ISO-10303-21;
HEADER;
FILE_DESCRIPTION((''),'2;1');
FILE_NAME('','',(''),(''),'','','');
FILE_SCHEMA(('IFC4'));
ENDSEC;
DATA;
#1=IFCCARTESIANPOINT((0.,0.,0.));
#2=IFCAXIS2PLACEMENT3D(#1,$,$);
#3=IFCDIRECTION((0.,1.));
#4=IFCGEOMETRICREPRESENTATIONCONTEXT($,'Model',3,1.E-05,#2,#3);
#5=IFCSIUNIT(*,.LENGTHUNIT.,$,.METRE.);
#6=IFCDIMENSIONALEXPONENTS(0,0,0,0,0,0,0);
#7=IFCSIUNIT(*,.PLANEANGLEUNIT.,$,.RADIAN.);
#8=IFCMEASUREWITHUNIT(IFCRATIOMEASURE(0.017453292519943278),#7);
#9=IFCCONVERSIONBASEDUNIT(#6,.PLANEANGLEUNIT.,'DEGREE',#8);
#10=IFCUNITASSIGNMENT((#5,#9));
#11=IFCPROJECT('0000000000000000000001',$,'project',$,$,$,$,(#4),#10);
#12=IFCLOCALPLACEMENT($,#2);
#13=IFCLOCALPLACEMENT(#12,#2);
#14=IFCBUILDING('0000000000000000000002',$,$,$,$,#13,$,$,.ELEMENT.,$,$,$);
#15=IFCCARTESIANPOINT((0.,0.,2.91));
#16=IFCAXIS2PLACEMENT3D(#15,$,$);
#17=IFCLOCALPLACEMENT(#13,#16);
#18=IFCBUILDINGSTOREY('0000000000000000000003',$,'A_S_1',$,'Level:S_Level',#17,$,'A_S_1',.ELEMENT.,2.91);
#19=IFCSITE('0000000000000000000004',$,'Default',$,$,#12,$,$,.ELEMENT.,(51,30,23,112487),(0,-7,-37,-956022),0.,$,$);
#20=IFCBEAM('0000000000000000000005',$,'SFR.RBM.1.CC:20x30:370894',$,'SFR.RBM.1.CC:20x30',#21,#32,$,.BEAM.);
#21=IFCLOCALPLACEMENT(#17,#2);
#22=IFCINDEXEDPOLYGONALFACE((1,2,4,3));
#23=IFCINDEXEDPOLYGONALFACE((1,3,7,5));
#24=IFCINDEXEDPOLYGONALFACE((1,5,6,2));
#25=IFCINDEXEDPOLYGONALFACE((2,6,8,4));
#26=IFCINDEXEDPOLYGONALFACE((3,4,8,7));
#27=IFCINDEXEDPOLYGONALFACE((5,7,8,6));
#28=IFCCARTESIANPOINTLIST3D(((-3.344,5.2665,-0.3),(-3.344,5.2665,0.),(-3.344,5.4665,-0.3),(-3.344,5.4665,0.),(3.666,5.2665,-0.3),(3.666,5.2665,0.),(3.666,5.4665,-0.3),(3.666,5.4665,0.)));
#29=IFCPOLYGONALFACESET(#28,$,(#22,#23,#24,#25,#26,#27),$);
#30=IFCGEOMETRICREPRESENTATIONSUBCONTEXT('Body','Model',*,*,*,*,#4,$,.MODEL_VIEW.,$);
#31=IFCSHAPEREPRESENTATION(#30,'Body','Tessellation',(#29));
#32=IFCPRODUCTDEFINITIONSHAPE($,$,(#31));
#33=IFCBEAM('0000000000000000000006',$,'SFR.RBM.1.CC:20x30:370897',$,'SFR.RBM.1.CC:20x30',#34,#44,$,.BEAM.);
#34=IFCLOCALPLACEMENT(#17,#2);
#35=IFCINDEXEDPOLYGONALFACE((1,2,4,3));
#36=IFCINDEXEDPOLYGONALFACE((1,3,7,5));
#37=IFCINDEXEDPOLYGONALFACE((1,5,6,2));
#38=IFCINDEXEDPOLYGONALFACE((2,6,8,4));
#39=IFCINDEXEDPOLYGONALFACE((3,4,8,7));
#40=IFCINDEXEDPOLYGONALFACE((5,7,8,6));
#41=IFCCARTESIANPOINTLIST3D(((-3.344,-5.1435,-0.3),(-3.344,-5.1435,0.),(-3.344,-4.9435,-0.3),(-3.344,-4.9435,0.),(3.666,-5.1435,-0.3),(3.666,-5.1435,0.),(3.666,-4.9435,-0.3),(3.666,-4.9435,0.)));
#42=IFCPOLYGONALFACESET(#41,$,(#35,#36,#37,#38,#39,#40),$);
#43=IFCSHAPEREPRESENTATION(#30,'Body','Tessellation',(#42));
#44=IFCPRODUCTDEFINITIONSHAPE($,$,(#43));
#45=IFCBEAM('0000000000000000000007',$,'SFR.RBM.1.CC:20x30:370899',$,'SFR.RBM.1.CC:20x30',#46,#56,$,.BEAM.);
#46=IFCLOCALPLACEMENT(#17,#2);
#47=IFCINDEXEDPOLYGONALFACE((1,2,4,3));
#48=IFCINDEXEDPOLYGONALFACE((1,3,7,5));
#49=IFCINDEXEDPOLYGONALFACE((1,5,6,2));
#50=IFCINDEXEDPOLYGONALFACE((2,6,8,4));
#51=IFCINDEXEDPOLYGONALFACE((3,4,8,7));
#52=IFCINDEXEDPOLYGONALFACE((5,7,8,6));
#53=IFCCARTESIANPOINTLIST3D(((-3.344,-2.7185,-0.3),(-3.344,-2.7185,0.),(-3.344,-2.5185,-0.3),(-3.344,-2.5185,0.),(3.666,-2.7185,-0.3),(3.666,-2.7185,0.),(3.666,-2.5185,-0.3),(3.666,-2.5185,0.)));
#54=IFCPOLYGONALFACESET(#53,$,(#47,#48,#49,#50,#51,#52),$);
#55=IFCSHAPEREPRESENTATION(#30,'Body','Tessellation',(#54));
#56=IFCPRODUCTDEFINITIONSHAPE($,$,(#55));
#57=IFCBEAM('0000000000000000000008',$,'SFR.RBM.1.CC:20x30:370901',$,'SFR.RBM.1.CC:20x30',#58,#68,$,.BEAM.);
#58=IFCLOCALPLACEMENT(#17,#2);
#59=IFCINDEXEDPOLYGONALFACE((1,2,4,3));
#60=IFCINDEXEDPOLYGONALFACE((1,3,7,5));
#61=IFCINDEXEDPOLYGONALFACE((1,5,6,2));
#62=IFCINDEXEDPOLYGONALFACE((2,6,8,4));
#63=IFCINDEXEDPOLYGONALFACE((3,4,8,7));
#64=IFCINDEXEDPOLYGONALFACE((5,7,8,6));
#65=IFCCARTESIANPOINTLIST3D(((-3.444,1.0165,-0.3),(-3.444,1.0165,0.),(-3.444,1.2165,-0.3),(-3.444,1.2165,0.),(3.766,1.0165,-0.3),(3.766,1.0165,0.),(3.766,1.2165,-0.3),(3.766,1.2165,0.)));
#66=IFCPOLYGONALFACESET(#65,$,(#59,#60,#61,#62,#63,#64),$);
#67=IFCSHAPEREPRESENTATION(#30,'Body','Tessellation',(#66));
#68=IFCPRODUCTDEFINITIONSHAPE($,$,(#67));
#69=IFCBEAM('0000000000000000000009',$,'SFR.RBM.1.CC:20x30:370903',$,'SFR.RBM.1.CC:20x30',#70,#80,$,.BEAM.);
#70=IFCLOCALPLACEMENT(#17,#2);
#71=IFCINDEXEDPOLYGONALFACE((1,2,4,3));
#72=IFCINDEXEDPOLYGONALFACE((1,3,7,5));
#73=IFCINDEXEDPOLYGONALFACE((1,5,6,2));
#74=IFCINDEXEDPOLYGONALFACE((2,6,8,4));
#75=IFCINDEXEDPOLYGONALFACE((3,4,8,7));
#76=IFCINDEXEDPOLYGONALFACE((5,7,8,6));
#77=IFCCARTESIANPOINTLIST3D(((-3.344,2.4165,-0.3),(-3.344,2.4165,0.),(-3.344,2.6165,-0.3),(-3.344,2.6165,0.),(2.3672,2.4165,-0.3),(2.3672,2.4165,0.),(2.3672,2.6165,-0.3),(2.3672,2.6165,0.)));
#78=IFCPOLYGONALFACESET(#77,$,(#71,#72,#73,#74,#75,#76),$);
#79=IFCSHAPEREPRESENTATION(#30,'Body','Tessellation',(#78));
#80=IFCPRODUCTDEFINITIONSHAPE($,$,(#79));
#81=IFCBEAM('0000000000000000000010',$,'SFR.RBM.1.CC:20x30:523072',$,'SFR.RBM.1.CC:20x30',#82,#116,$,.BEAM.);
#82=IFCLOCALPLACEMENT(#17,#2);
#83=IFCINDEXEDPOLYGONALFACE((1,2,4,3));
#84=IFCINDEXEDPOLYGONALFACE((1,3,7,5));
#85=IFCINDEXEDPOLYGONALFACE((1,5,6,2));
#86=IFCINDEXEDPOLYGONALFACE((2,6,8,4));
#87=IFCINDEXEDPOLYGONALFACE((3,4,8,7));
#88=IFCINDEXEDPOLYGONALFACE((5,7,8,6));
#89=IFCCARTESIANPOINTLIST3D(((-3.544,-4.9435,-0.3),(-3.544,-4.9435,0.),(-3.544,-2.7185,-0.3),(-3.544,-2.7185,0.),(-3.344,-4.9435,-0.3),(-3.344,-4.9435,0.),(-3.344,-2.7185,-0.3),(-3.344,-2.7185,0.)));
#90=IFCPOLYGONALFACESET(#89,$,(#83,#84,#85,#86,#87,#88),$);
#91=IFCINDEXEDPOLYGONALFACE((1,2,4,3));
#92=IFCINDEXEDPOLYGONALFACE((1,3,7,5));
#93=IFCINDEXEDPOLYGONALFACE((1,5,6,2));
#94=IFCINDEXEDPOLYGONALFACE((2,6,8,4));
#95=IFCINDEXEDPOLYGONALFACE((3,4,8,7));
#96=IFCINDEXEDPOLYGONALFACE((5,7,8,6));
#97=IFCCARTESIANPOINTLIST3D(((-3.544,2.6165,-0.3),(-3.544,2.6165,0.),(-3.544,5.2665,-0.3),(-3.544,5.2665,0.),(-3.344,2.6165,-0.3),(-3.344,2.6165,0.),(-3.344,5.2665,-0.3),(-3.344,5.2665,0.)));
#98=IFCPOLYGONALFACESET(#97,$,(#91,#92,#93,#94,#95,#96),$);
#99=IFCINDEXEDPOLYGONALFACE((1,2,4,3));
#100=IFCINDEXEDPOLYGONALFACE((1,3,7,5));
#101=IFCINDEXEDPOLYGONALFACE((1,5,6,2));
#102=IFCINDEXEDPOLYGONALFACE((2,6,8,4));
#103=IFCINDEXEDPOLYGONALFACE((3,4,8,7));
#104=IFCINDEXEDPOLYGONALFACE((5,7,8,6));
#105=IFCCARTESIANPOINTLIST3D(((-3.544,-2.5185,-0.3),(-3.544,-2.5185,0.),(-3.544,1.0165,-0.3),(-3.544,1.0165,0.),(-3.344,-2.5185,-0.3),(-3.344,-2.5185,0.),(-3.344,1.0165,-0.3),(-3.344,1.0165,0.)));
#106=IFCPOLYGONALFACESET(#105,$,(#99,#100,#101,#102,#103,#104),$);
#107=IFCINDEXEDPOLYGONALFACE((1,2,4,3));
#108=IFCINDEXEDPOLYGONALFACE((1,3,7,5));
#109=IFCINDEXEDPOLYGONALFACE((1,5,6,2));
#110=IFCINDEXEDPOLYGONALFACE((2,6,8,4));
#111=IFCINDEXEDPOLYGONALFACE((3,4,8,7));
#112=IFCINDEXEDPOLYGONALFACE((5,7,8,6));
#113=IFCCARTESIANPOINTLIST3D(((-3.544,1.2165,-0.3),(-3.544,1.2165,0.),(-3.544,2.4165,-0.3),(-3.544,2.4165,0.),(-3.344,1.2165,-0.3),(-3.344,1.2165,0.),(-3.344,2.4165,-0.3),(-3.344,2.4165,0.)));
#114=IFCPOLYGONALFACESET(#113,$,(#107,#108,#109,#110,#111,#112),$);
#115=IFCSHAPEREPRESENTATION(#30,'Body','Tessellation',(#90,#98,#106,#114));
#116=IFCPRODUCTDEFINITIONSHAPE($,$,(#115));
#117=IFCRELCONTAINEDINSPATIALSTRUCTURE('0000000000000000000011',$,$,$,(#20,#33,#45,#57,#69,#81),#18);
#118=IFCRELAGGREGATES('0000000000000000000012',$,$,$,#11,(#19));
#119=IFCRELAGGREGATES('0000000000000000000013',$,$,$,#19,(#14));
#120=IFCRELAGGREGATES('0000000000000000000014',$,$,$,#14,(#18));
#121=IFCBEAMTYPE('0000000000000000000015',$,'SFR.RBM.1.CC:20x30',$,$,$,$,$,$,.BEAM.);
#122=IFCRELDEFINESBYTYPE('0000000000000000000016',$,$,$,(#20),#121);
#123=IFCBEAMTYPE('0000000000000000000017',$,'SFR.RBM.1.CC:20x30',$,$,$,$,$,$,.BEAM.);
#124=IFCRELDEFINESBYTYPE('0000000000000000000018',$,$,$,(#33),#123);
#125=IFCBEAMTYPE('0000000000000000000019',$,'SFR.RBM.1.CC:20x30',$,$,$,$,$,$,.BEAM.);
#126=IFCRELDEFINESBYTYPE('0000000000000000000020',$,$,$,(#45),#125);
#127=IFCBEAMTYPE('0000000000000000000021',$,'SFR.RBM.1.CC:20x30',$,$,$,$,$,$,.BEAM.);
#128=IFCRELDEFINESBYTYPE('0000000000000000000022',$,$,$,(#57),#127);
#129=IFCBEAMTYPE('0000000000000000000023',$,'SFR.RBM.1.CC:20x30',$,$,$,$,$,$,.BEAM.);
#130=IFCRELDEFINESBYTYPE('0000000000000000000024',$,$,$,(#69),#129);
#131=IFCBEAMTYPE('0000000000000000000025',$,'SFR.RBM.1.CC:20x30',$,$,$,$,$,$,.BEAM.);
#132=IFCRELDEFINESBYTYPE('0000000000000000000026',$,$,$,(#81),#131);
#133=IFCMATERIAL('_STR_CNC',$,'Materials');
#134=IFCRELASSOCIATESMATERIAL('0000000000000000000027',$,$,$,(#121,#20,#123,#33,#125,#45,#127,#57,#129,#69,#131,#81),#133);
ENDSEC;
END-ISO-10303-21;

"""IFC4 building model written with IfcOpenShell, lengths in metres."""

from ifc_helpers import new_model, entity, si_unit, converted_unit, direction, frame, origin, place, context, subcontext, project, spatial, indexed_curve, outline, extrude, source, transform, mapped, material, type_object, type_shapes, element, save


model = new_model("IFC4")

# Units and contexts
model_context = context("Model", 3, precision=1e-05, world=origin(), true_north=direction((0.0, 1.0)))
body_context = subcontext(model_context, "Body", "Model", "MODEL_VIEW")
ifc_project = project(units=[si_unit("LENGTHUNIT", "METRE"), converted_unit("PLANEANGLEUNIT", "DEGREE", entity("IfcRatioMeasure", 0.017453292519943278), si_unit("PLANEANGLEUNIT", "RADIAN"), dimensions=[0, 0, 0, 0, 0, 0, 0])], contexts=[model_context])

# Site, building, storey
site_placement = place(None, origin())
site = spatial("IfcSite", under=ifc_project, at=site_placement, Name="Default", CompositionType="ELEMENT", RefLatitude=(51, 30, 23, 112487), RefLongitude=(0, -7, -37, -956022), RefElevation=0.0)
building_placement = place(site_placement, origin())
building = spatial("IfcBuilding", under=site, at=building_placement, CompositionType="ELEMENT")
storey_placement = place(building_placement, frame((0.0, 0.0, 2.91)))
storey = spatial("IfcBuildingStorey", under=building, at=storey_placement, Name="A_S_1", ObjectType="Level:S_Level", LongName="A_S_1", CompositionType="ELEMENT", Elevation=2.91)

# Shared definitions
ifc_material_1 = material(Name="_STR_CNC", Category="Materials")

# Beams
beam_type_1 = type_object("IfcBeamType", Name="SFR.RBM.1.CC:20x30", PredefinedType="BEAM", material=ifc_material_1)
shared_shape_1 = source(origin(), body_context, "Body", "SweptSolid", [
    extrude(outline(indexed_curve([(-0.15, -0.1), (0.15, -0.1), (0.15, 0.1), (-0.15, 0.1), (-0.15, -0.1)], self_intersect=False)), frame((3.666, 5.3665, 2.76), z_axis=(-1.0, 0.0, 0.0), x_axis=(0.0, 0.0, -1.0)), (0.0, 0.0, 1.0), 7.01),
])
type_shapes(beam_type_1, [shared_shape_1])
beam_1_placement = place(storey_placement, frame((0.0, 0.0, -2.91)))
element("IfcBeam", 1, at=beam_1_placement, inside=storey, type_object=beam_type_1, material=ifc_material_1, Name="SFR.RBM.1.CC:20x30:370894", ObjectType="SFR.RBM.1.CC:20x30", PredefinedType="BEAM", context=body_context, shape_type="MappedRepresentation", body=[
    mapped(shared_shape_1, transform((0.0, 0.0, 0.0), scale=1.0)),
])
beam_type_2 = type_object("IfcBeamType", Name="SFR.RBM.1.CC:20x30", PredefinedType="BEAM", material=ifc_material_1)
shared_shape_2 = source(origin(), body_context, "Body", "SweptSolid", [
    extrude(outline(indexed_curve([(-0.15, -0.1), (0.15, -0.1), (0.15, 0.1), (-0.15, 0.1), (-0.15, -0.1)], self_intersect=False)), frame((3.666, -5.0435, 2.76), z_axis=(-1.0, 0.0, 0.0), x_axis=(0.0, 0.0, -1.0)), (0.0, 0.0, 1.0), 7.01),
])
type_shapes(beam_type_2, [shared_shape_2])
beam_2_placement = place(storey_placement, frame((0.0, 0.0, -2.91)))
element("IfcBeam", 2, at=beam_2_placement, inside=storey, type_object=beam_type_2, material=ifc_material_1, Name="SFR.RBM.1.CC:20x30:370897", ObjectType="SFR.RBM.1.CC:20x30", PredefinedType="BEAM", context=body_context, shape_type="MappedRepresentation", body=[
    mapped(shared_shape_2, transform((0.0, 0.0, 0.0), scale=1.0)),
])
beam_type_3 = type_object("IfcBeamType", Name="SFR.RBM.1.CC:20x30", PredefinedType="BEAM", material=ifc_material_1)
shared_shape_3 = source(origin(), body_context, "Body", "SweptSolid", [
    extrude(outline(indexed_curve([(-0.15, -0.1), (0.15, -0.1), (0.15, 0.1), (-0.15, 0.1), (-0.15, -0.1)], self_intersect=False)), frame((3.666, -2.6185, 2.76), z_axis=(-1.0, 0.0, 0.0), x_axis=(0.0, 0.0, -1.0)), (0.0, 0.0, 1.0), 7.01),
])
type_shapes(beam_type_3, [shared_shape_3])
beam_3_placement = place(storey_placement, frame((0.0, 0.0, -2.91)))
element("IfcBeam", 3, at=beam_3_placement, inside=storey, type_object=beam_type_3, material=ifc_material_1, Name="SFR.RBM.1.CC:20x30:370899", ObjectType="SFR.RBM.1.CC:20x30", PredefinedType="BEAM", context=body_context, shape_type="MappedRepresentation", body=[
    mapped(shared_shape_3, transform((0.0, 0.0, 0.0), scale=1.0)),
])
beam_type_4 = type_object("IfcBeamType", Name="SFR.RBM.1.CC:20x30", PredefinedType="BEAM", material=ifc_material_1)
shared_shape_4 = source(origin(), body_context, "Body", "SweptSolid", [
    extrude(outline(indexed_curve([(-0.15, -0.1), (0.15, -0.1), (0.15, 0.1), (-0.15, 0.1), (-0.15, -0.1)], self_intersect=False)), frame((3.766, 1.1165, 2.76), z_axis=(-1.0, 0.0, 0.0), x_axis=(0.0, 0.0, -1.0)), (0.0, 0.0, 1.0), 7.21),
])
type_shapes(beam_type_4, [shared_shape_4])
beam_4_placement = place(storey_placement, frame((0.0, 0.0, -2.91)))
element("IfcBeam", 4, at=beam_4_placement, inside=storey, type_object=beam_type_4, material=ifc_material_1, Name="SFR.RBM.1.CC:20x30:370901", ObjectType="SFR.RBM.1.CC:20x30", PredefinedType="BEAM", context=body_context, shape_type="MappedRepresentation", body=[
    mapped(shared_shape_4, transform((0.0, 0.0, 0.0), scale=1.0)),
])
beam_type_5 = type_object("IfcBeamType", Name="SFR.RBM.1.CC:20x30", PredefinedType="BEAM", material=ifc_material_1)
shared_shape_5 = source(origin(), body_context, "Body", "SweptSolid", [
    extrude(outline(indexed_curve([(-0.15, -0.1), (0.15, -0.1), (0.15, 0.1), (-0.15, 0.1), (-0.15, -0.1)], self_intersect=False)), frame((2.3672, 2.5165, 2.76), z_axis=(-1.0, 0.0, 0.0), x_axis=(0.0, 0.0, -1.0)), (0.0, 0.0, 1.0), 5.7112),
])
type_shapes(beam_type_5, [shared_shape_5])
beam_5_placement = place(storey_placement, frame((0.0, 0.0, -2.91)))
element("IfcBeam", 5, at=beam_5_placement, inside=storey, type_object=beam_type_5, material=ifc_material_1, Name="SFR.RBM.1.CC:20x30:370903", ObjectType="SFR.RBM.1.CC:20x30", PredefinedType="BEAM", context=body_context, shape_type="MappedRepresentation", body=[
    mapped(shared_shape_5, transform((0.0, 0.0, 0.0), scale=1.0)),
])
beam_type_6 = type_object("IfcBeamType", Name="SFR.RBM.1.CC:20x30", PredefinedType="BEAM", material=ifc_material_1)
shared_shape_6 = source(origin(), body_context, "Body", "SweptSolid", [
    extrude(outline(indexed_curve([(-0.1, -0.15), (0.1, -0.15), (0.1, 0.15), (-0.1, 0.15), (-0.1, -0.15)], self_intersect=False)), frame((-3.444, -2.7185, 2.76), z_axis=(0.0, -1.0, 0.0), x_axis=(-1.0, 0.0, 0.0)), (0.0, 0.0, 1.0), 2.225),
    extrude(outline(indexed_curve([(-0.1, -0.15), (0.1, -0.15), (0.1, 0.15), (-0.1, 0.15), (-0.1, -0.15)], self_intersect=False)), frame((-3.444, 5.2665, 2.76), z_axis=(0.0, -1.0, 0.0), x_axis=(-1.0, 0.0, 0.0)), (0.0, 0.0, 1.0), 2.65),
    extrude(outline(indexed_curve([(-0.1, -0.15), (0.1, -0.15), (0.1, 0.15), (-0.1, 0.15), (-0.1, -0.15)], self_intersect=False)), frame((-3.444, 1.0165, 2.76), z_axis=(0.0, -1.0, 0.0), x_axis=(-1.0, 0.0, 0.0)), (0.0, 0.0, 1.0), 3.535),
    extrude(outline(indexed_curve([(-0.1, -0.15), (0.1, -0.15), (0.1, 0.15), (-0.1, 0.15), (-0.1, -0.15)], self_intersect=False)), frame((-3.444, 2.4165, 2.76), z_axis=(0.0, -1.0, 0.0), x_axis=(-1.0, 0.0, 0.0)), (0.0, 0.0, 1.0), 1.2),
])
type_shapes(beam_type_6, [shared_shape_6])
beam_6_placement = place(storey_placement, frame((0.0, 0.0, -2.91)))
element("IfcBeam", 6, at=beam_6_placement, inside=storey, type_object=beam_type_6, material=ifc_material_1, Name="SFR.RBM.1.CC:20x30:523072", ObjectType="SFR.RBM.1.CC:20x30", PredefinedType="BEAM", context=body_context, shape_type="MappedRepresentation", body=[
    mapped(shared_shape_6, transform((0.0, 0.0, 0.0), scale=1.0)),
])

save(model, "model.ifc")
